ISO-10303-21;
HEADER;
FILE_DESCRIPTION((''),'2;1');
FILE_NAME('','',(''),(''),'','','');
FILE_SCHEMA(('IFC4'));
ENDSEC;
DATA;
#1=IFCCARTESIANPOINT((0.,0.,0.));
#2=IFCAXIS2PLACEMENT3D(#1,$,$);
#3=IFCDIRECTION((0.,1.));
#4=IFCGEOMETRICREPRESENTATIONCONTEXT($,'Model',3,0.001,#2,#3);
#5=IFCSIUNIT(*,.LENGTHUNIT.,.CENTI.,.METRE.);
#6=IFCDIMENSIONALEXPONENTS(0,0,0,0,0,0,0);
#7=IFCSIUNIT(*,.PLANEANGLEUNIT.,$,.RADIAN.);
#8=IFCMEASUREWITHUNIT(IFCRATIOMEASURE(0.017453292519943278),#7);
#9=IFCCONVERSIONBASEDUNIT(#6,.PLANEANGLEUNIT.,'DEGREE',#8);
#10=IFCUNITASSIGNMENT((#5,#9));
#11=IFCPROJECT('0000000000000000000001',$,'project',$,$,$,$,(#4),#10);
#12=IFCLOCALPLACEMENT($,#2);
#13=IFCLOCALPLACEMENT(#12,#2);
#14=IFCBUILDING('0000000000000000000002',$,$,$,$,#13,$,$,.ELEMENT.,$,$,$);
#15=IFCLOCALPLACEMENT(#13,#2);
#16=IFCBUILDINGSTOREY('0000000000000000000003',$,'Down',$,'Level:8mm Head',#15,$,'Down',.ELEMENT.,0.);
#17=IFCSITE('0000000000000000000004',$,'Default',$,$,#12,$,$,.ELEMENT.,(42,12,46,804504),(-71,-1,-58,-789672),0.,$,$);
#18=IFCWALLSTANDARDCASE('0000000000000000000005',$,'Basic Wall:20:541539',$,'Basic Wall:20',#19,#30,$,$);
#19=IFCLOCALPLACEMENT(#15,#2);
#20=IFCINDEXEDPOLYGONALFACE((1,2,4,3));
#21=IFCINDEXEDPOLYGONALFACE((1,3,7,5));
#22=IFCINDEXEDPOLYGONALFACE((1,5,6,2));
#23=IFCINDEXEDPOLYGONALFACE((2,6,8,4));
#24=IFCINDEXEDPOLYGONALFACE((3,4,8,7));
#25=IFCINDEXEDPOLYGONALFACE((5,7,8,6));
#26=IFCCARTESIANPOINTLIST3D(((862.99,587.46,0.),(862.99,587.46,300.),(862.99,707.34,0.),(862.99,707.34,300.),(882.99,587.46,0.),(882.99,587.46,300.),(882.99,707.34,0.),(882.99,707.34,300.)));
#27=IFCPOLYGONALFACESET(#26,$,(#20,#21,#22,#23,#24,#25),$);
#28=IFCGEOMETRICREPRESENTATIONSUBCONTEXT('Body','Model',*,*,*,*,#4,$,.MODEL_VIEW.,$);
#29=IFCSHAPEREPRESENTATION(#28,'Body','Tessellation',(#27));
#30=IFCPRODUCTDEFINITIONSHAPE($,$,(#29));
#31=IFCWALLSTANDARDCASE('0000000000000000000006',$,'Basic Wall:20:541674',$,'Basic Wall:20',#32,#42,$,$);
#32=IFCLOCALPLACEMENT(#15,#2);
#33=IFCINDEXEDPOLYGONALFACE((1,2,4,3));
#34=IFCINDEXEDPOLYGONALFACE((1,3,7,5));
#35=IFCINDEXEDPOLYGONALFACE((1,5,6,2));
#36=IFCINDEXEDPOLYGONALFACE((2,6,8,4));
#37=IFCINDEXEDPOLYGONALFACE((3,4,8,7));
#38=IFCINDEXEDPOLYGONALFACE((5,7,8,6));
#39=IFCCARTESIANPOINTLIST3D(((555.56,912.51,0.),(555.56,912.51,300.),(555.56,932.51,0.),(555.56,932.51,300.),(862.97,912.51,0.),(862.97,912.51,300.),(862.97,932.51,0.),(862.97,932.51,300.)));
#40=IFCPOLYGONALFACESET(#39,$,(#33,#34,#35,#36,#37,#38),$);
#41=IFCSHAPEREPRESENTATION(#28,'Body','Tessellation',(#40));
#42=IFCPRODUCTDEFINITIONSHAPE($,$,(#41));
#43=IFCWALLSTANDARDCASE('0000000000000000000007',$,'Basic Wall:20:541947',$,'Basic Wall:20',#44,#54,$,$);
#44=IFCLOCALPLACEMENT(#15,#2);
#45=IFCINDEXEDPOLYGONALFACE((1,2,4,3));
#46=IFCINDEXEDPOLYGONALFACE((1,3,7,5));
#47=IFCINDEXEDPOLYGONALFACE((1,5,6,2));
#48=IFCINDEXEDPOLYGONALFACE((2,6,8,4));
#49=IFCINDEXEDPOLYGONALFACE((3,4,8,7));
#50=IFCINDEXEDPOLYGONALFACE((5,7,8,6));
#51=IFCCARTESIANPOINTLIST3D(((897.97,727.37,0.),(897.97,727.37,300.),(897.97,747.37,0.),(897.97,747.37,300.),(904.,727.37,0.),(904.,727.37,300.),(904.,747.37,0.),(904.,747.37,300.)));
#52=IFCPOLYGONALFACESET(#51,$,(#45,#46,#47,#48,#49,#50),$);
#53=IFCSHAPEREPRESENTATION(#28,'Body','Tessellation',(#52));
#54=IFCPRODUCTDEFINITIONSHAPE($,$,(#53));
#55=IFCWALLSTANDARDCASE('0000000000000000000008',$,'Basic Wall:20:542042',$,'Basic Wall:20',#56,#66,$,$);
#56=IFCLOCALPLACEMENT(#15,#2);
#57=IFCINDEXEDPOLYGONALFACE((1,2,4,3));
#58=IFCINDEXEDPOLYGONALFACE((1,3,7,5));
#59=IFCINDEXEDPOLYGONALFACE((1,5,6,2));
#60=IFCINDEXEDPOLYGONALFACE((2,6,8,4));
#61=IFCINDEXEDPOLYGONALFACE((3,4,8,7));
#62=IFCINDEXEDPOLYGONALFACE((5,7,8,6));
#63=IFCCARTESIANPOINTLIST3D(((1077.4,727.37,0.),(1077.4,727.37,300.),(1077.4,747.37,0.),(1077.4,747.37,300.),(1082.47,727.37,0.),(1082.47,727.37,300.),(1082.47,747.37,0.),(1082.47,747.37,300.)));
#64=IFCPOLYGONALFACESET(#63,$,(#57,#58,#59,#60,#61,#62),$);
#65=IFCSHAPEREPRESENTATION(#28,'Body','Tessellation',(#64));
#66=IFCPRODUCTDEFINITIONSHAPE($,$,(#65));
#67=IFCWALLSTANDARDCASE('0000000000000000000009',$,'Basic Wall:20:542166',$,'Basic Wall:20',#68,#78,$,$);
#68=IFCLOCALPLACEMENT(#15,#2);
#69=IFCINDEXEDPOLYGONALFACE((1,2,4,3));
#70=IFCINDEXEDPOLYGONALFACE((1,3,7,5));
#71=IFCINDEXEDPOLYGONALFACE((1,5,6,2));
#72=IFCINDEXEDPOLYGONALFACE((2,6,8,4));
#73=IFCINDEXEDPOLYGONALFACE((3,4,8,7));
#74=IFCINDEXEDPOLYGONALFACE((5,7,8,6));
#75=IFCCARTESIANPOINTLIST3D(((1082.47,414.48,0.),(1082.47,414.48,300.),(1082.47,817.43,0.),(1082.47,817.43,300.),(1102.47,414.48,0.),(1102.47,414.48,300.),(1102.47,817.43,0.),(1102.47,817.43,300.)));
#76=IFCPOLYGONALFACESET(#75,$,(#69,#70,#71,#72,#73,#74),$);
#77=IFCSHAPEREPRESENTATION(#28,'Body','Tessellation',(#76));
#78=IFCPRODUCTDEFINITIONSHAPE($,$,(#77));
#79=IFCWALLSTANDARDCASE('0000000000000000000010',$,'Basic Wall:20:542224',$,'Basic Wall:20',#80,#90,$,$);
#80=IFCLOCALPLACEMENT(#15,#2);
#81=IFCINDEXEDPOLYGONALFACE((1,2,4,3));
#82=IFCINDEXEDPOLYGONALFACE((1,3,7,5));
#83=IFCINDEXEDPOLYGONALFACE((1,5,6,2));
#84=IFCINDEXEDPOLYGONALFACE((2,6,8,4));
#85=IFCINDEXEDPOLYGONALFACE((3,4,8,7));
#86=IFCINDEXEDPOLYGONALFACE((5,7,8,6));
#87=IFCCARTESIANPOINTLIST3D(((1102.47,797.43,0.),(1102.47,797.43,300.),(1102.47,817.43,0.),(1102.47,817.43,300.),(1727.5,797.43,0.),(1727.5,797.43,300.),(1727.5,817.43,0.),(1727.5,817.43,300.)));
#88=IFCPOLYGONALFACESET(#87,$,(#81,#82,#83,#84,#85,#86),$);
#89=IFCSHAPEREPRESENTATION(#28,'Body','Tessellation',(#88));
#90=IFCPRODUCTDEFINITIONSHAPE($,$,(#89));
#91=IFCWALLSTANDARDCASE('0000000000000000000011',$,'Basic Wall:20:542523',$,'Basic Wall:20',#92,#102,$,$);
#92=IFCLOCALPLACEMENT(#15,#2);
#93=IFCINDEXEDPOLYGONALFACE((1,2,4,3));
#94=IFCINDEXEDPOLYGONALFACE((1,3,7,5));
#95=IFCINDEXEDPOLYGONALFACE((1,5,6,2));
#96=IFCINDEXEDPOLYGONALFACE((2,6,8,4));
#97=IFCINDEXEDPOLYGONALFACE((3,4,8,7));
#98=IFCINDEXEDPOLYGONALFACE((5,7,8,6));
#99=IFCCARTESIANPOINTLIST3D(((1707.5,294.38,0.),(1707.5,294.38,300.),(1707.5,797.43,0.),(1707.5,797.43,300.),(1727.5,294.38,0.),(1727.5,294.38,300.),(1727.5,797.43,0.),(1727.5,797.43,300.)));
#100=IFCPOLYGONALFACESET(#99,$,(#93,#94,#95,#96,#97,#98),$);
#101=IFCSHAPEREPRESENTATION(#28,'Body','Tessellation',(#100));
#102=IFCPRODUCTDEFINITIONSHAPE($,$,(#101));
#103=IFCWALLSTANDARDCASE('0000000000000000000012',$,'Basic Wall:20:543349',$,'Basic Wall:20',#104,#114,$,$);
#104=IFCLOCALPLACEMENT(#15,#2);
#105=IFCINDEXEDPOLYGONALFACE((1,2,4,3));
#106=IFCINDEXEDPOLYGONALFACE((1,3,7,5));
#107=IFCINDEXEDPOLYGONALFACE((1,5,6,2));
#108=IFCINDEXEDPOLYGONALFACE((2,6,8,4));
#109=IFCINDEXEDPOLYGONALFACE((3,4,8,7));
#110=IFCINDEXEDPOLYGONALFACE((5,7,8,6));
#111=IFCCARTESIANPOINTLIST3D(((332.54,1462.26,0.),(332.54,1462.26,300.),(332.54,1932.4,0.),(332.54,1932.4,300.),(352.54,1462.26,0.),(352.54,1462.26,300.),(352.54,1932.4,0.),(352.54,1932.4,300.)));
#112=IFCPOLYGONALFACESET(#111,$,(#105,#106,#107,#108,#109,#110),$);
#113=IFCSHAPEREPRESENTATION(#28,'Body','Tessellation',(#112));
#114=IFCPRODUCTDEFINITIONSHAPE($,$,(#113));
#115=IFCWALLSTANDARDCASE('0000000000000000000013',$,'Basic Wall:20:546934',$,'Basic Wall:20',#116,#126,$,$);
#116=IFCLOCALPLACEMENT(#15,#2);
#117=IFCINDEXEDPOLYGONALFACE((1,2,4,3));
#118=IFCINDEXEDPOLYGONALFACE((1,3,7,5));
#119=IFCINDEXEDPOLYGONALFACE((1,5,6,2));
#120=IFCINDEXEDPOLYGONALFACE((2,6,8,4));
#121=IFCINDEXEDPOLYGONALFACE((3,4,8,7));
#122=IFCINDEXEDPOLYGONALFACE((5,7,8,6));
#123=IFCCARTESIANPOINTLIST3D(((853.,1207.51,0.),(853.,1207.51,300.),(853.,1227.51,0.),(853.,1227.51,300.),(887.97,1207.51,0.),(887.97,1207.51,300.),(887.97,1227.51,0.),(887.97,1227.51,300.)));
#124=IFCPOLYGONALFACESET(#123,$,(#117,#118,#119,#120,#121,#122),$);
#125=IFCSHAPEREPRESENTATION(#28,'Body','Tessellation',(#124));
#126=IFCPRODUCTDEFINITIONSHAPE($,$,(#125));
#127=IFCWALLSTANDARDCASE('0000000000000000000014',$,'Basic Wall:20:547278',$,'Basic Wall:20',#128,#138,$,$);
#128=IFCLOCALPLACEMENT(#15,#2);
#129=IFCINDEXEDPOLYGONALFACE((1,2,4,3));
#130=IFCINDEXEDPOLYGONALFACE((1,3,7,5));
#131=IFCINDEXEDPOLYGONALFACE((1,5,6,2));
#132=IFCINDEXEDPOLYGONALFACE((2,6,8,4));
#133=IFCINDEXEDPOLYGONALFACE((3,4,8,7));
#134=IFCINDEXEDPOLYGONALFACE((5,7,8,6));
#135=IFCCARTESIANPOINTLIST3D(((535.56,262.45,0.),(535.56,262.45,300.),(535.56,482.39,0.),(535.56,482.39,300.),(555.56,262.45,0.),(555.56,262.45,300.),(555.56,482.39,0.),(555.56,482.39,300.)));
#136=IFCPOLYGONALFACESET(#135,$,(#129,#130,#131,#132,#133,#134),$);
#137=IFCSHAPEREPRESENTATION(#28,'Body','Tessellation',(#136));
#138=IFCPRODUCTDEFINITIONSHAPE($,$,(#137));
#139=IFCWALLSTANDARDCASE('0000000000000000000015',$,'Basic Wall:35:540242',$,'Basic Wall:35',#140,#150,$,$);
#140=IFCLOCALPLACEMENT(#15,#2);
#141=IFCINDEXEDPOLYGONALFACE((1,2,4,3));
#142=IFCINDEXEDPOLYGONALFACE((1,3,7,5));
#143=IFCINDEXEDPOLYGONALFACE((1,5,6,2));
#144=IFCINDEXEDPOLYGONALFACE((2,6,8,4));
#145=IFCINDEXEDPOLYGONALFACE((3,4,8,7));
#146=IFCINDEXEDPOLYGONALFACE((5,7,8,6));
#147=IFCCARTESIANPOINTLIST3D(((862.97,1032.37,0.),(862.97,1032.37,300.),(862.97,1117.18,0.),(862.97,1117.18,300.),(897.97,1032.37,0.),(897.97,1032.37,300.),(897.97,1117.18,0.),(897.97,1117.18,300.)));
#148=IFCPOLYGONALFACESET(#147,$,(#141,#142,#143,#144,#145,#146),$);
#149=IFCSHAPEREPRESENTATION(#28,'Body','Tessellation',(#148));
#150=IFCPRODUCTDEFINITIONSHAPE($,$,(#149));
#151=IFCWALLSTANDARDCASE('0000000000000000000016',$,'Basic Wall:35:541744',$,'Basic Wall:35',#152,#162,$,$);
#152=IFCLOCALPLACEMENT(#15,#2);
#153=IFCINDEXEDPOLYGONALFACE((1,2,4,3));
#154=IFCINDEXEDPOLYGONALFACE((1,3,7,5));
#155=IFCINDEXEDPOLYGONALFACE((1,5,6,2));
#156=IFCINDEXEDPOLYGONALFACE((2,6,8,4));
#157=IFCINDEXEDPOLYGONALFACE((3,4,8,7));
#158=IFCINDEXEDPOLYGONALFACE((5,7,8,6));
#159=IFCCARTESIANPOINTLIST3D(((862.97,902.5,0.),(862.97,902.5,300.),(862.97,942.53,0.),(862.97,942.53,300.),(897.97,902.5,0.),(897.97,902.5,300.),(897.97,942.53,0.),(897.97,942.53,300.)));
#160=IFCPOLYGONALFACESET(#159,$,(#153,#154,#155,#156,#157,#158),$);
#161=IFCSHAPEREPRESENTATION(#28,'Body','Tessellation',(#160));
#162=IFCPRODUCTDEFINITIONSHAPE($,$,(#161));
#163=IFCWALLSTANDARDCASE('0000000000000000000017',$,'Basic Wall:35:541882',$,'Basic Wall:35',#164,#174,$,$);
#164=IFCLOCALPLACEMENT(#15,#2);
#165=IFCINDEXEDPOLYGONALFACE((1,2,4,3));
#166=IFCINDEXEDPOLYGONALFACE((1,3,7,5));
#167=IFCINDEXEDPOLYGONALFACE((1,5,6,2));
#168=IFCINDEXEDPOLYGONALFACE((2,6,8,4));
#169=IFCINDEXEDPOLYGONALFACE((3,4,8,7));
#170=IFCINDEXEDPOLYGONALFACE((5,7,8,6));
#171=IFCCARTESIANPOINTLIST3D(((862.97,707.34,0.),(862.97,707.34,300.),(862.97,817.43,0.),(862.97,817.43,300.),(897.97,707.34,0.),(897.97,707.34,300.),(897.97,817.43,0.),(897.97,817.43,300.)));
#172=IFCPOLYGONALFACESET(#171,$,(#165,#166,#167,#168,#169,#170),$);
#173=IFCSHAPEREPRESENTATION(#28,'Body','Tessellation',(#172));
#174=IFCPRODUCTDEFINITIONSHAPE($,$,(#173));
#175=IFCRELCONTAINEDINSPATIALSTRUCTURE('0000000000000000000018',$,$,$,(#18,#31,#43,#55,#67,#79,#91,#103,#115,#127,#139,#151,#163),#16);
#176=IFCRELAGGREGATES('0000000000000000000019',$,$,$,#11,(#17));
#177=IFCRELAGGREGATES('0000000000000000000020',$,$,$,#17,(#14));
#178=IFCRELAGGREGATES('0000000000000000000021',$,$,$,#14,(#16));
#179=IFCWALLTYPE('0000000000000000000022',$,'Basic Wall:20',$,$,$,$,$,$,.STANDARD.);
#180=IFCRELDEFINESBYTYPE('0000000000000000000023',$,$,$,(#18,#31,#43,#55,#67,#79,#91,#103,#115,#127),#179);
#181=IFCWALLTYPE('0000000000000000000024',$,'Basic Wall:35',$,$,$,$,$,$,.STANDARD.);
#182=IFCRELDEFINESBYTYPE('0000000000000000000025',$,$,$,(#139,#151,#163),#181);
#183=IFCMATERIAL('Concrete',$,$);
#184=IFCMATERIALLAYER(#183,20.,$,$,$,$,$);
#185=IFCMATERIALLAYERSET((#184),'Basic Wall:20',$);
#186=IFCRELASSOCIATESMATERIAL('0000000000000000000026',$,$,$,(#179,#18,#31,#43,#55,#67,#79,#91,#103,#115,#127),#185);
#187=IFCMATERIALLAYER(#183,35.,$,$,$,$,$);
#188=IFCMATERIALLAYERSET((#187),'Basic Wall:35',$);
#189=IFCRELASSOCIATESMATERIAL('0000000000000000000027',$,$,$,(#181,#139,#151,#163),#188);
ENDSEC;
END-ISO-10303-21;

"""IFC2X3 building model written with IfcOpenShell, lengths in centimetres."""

from ifc_helpers import new_model, entity, si_unit, converted_unit, direction, frame, frame_2d, origin, place, context, subcontext, project, spatial, rectangle, extrude, material, layer, layer_set, layer_usage, type_object, element, save


model = new_model("IFC2X3")

# Units and contexts
model_context = context("Model", 3, precision=0.001, world=origin(), true_north=direction((0.0, 1.0)))
body_context = subcontext(model_context, "Body", "Model", "MODEL_VIEW")
ifc_project = project(units=[si_unit("LENGTHUNIT", "METRE", prefix="CENTI"), converted_unit("PLANEANGLEUNIT", "DEGREE", entity("IfcRatioMeasure", 0.017453292519943278), si_unit("PLANEANGLEUNIT", "RADIAN"), dimensions=[0, 0, 0, 0, 0, 0, 0])], contexts=[model_context])

# Site, building, storey
site_placement = place(None, origin())
site = spatial("IfcSite", under=ifc_project, at=site_placement, Name="Default", CompositionType="ELEMENT", RefLatitude=(42, 12, 46, 804504), RefLongitude=(-71, -1, -58, -789672), RefElevation=0.0)
building_placement = place(site_placement, origin())
building = spatial("IfcBuilding", under=site, at=building_placement, CompositionType="ELEMENT")
storey_placement = place(building_placement, origin())
storey = spatial("IfcBuildingStorey", under=building, at=storey_placement, Name="Down", ObjectType="Level:8mm Head", LongName="Down", CompositionType="ELEMENT", Elevation=0.0)

# Walls
ifc_material = material(Name="Concrete")
ifc_layer_1 = layer(ifc_material, 20.0)
ifc_layer_set_1 = layer_set([ifc_layer_1], Name="Basic Wall:20")
wall_type_1 = type_object("IfcWallType", Name="Basic Wall:20", PredefinedType="STANDARD", material=ifc_layer_set_1)
ifc_layer_usage_1 = layer_usage(ifc_layer_set_1, "AXIS2", "POSITIVE", -10.0)
wall_1_placement = place(storey_placement, frame((872.99, 587.46, 0.0), z_axis=(0.0, 0.0, 1.0), x_axis=(0.0, 1.0, 0.0)))
element("IfcWallStandardCase", 1, at=wall_1_placement, inside=storey, type_object=wall_type_1, material=ifc_layer_usage_1, Name="Basic Wall:20:541539", ObjectType="Basic Wall:20", context=body_context, shape_type="SweptSolid", body=[
    extrude(rectangle(XDim=119.88, YDim=20.0, at=frame_2d((59.94, 0.0), x_axis=(-1.0, 0.0))), origin(), (0.0, 0.0, 1.0), 300.0),
])
ifc_layer_usage_2 = layer_usage(ifc_layer_set_1, "AXIS2", "POSITIVE", -10.0)
wall_2_placement = place(storey_placement, frame((555.56, 922.51, 0.0)))
element("IfcWallStandardCase", 2, at=wall_2_placement, inside=storey, type_object=wall_type_1, material=ifc_layer_usage_2, Name="Basic Wall:20:541674", ObjectType="Basic Wall:20", context=body_context, shape_type="SweptSolid", body=[
    extrude(rectangle(XDim=307.41, YDim=20.0, at=frame_2d((153.71, 0.0), x_axis=(-1.0, 0.0))), origin(), (0.0, 0.0, 1.0), 300.0),
])
ifc_layer_usage_3 = layer_usage(ifc_layer_set_1, "AXIS2", "NEGATIVE", 10.0)
wall_3_placement = place(storey_placement, frame((897.97, 737.37, 0.0)))
element("IfcWallStandardCase", 3, at=wall_3_placement, inside=storey, type_object=wall_type_1, material=ifc_layer_usage_3, Name="Basic Wall:20:541947", ObjectType="Basic Wall:20", context=body_context, shape_type="SweptSolid", body=[
    extrude(rectangle(XDim=6.03, YDim=20.0, at=frame_2d((3.01, 0.0), x_axis=(-1.0, 0.0))), origin(), (0.0, 0.0, 1.0), 300.0),
])
ifc_layer_usage_4 = layer_usage(ifc_layer_set_1, "AXIS2", "NEGATIVE", 10.0)
wall_4_placement = place(storey_placement, frame((1077.4, 737.37, 0.0)))
element("IfcWallStandardCase", 4, at=wall_4_placement, inside=storey, type_object=wall_type_1, material=ifc_layer_usage_4, Name="Basic Wall:20:542042", ObjectType="Basic Wall:20", context=body_context, shape_type="SweptSolid", body=[
    extrude(rectangle(XDim=5.07, YDim=20.0, at=frame_2d((2.54, 0.0), x_axis=(-1.0, 0.0))), origin(), (0.0, 0.0, 1.0), 300.0),
])
ifc_layer_usage_5 = layer_usage(ifc_layer_set_1, "AXIS2", "POSITIVE", -10.0)
wall_5_placement = place(storey_placement, frame((1092.47, 414.48, 0.0), z_axis=(0.0, 0.0, 1.0), x_axis=(0.0, 1.0, 0.0)))
element("IfcWallStandardCase", 5, at=wall_5_placement, inside=storey, type_object=wall_type_1, material=ifc_layer_usage_5, Name="Basic Wall:20:542166", ObjectType="Basic Wall:20", context=body_context, shape_type="SweptSolid", body=[
    extrude(rectangle(XDim=402.95, YDim=20.0, at=frame_2d((201.48, 0.0), x_axis=(-1.0, 0.0))), origin(), (0.0, 0.0, 1.0), 300.0),
])
ifc_layer_usage_6 = layer_usage(ifc_layer_set_1, "AXIS2", "NEGATIVE", 10.0)
wall_6_placement = place(storey_placement, frame((1102.47, 807.43, 0.0)))
element("IfcWallStandardCase", 6, at=wall_6_placement, inside=storey, type_object=wall_type_1, material=ifc_layer_usage_6, Name="Basic Wall:20:542224", ObjectType="Basic Wall:20", context=body_context, shape_type="SweptSolid", body=[
    extrude(rectangle(XDim=625.02, YDim=20.0, at=frame_2d((312.51, 0.0), x_axis=(-1.0, 0.0))), origin(), (0.0, 0.0, 1.0), 300.0),
])
ifc_layer_usage_7 = layer_usage(ifc_layer_set_1, "AXIS2", "NEGATIVE", 10.0)
wall_7_placement = place(storey_placement, frame((1717.5, 797.43, 0.0), z_axis=(0.0, 0.0, 1.0), x_axis=(0.0, -1.0, 0.0)))
element("IfcWallStandardCase", 7, at=wall_7_placement, inside=storey, type_object=wall_type_1, material=ifc_layer_usage_7, Name="Basic Wall:20:542523", ObjectType="Basic Wall:20", context=body_context, shape_type="SweptSolid", body=[
    extrude(rectangle(XDim=503.05, YDim=20.0, at=frame_2d((251.53, 0.0), x_axis=(-1.0, 0.0))), origin(), (0.0, 0.0, 1.0), 300.0),
])
ifc_layer_usage_8 = layer_usage(ifc_layer_set_1, "AXIS2", "POSITIVE", -10.0)
wall_8_placement = place(storey_placement, frame((342.54, 1932.4, 0.0), z_axis=(0.0, 0.0, 1.0), x_axis=(0.0, -1.0, 0.0)))
element("IfcWallStandardCase", 8, at=wall_8_placement, inside=storey, type_object=wall_type_1, material=ifc_layer_usage_8, Name="Basic Wall:20:543349", ObjectType="Basic Wall:20", context=body_context, shape_type="SweptSolid", body=[
    extrude(rectangle(XDim=470.13, YDim=20.0, at=frame_2d((235.07, 0.0), x_axis=(-1.0, 0.0))), origin(), (0.0, 0.0, 1.0), 300.0),
])
ifc_layer_usage_9 = layer_usage(ifc_layer_set_1, "AXIS2", "POSITIVE", -10.0)
wall_9_placement = place(storey_placement, frame((853.0, 1217.51, 0.0)))
element("IfcWallStandardCase", 9, at=wall_9_placement, inside=storey, type_object=wall_type_1, material=ifc_layer_usage_9, Name="Basic Wall:20:546934", ObjectType="Basic Wall:20", context=body_context, shape_type="SweptSolid", body=[
    extrude(rectangle(XDim=34.96, YDim=20.0, at=frame_2d((17.48, 0.0), x_axis=(-1.0, 0.0))), origin(), (0.0, 0.0, 1.0), 300.0),
])
ifc_layer_usage_10 = layer_usage(ifc_layer_set_1, "AXIS2", "POSITIVE", -10.0)
wall_10_placement = place(storey_placement, frame((545.56, 482.39, 0.0), z_axis=(0.0, 0.0, 1.0), x_axis=(0.0, -1.0, 0.0)))
element("IfcWallStandardCase", 10, at=wall_10_placement, inside=storey, type_object=wall_type_1, material=ifc_layer_usage_10, Name="Basic Wall:20:547278", ObjectType="Basic Wall:20", context=body_context, shape_type="SweptSolid", body=[
    extrude(rectangle(XDim=219.94, YDim=20.0, at=frame_2d((109.97, 0.0), x_axis=(-1.0, 0.0))), origin(), (0.0, 0.0, 1.0), 300.0),
])
ifc_layer_2 = layer(ifc_material, 35.0)
ifc_layer_set_2 = layer_set([ifc_layer_2], Name="Basic Wall:35")
ifc_layer_usage_11 = layer_usage(ifc_layer_set_2, "AXIS2", "POSITIVE", -17.5)
wall_type_2 = type_object("IfcWallType", Name="Basic Wall:35", PredefinedType="STANDARD", material=ifc_layer_set_2)
wall_11_placement = place(storey_placement, frame((880.47, 1032.37, 0.0), z_axis=(0.0, 0.0, 1.0), x_axis=(0.0, 1.0, 0.0)))
element("IfcWallStandardCase", 11, at=wall_11_placement, inside=storey, type_object=wall_type_2, material=ifc_layer_usage_11, Name="Basic Wall:35:540242", ObjectType="Basic Wall:35", context=body_context, shape_type="SweptSolid", body=[
    extrude(rectangle(XDim=84.82, YDim=35.0, at=frame_2d((42.41, 0.0), x_axis=(-1.0, 0.0))), origin(), (0.0, 0.0, 1.0), 300.0),
])
ifc_layer_usage_12 = layer_usage(ifc_layer_set_2, "AXIS2", "NEGATIVE", 17.5)
wall_12_placement = place(storey_placement, frame((880.47, 902.5, 0.0), z_axis=(0.0, 0.0, 1.0), x_axis=(0.0, 1.0, 0.0)))
element("IfcWallStandardCase", 12, at=wall_12_placement, inside=storey, type_object=wall_type_2, material=ifc_layer_usage_12, Name="Basic Wall:35:541744", ObjectType="Basic Wall:35", context=body_context, shape_type="SweptSolid", body=[
    extrude(rectangle(XDim=40.03, YDim=35.0, at=frame_2d((20.02, 0.0), x_axis=(-1.0, 0.0))), origin(), (0.0, 0.0, 1.0), 300.0),
])
ifc_layer_usage_13 = layer_usage(ifc_layer_set_2, "AXIS2", "POSITIVE", -17.5)
wall_13_placement = place(storey_placement, frame((880.47, 817.43, 0.0), z_axis=(0.0, 0.0, 1.0), x_axis=(0.0, -1.0, 0.0)))
element("IfcWallStandardCase", 13, at=wall_13_placement, inside=storey, type_object=wall_type_2, material=ifc_layer_usage_13, Name="Basic Wall:35:541882", ObjectType="Basic Wall:35", context=body_context, shape_type="SweptSolid", body=[
    extrude(rectangle(XDim=110.09, YDim=35.0, at=frame_2d((55.05, 0.0), x_axis=(-1.0, 0.0))), origin(), (0.0, 0.0, 1.0), 300.0),
])

save(model, "model.ifc")
